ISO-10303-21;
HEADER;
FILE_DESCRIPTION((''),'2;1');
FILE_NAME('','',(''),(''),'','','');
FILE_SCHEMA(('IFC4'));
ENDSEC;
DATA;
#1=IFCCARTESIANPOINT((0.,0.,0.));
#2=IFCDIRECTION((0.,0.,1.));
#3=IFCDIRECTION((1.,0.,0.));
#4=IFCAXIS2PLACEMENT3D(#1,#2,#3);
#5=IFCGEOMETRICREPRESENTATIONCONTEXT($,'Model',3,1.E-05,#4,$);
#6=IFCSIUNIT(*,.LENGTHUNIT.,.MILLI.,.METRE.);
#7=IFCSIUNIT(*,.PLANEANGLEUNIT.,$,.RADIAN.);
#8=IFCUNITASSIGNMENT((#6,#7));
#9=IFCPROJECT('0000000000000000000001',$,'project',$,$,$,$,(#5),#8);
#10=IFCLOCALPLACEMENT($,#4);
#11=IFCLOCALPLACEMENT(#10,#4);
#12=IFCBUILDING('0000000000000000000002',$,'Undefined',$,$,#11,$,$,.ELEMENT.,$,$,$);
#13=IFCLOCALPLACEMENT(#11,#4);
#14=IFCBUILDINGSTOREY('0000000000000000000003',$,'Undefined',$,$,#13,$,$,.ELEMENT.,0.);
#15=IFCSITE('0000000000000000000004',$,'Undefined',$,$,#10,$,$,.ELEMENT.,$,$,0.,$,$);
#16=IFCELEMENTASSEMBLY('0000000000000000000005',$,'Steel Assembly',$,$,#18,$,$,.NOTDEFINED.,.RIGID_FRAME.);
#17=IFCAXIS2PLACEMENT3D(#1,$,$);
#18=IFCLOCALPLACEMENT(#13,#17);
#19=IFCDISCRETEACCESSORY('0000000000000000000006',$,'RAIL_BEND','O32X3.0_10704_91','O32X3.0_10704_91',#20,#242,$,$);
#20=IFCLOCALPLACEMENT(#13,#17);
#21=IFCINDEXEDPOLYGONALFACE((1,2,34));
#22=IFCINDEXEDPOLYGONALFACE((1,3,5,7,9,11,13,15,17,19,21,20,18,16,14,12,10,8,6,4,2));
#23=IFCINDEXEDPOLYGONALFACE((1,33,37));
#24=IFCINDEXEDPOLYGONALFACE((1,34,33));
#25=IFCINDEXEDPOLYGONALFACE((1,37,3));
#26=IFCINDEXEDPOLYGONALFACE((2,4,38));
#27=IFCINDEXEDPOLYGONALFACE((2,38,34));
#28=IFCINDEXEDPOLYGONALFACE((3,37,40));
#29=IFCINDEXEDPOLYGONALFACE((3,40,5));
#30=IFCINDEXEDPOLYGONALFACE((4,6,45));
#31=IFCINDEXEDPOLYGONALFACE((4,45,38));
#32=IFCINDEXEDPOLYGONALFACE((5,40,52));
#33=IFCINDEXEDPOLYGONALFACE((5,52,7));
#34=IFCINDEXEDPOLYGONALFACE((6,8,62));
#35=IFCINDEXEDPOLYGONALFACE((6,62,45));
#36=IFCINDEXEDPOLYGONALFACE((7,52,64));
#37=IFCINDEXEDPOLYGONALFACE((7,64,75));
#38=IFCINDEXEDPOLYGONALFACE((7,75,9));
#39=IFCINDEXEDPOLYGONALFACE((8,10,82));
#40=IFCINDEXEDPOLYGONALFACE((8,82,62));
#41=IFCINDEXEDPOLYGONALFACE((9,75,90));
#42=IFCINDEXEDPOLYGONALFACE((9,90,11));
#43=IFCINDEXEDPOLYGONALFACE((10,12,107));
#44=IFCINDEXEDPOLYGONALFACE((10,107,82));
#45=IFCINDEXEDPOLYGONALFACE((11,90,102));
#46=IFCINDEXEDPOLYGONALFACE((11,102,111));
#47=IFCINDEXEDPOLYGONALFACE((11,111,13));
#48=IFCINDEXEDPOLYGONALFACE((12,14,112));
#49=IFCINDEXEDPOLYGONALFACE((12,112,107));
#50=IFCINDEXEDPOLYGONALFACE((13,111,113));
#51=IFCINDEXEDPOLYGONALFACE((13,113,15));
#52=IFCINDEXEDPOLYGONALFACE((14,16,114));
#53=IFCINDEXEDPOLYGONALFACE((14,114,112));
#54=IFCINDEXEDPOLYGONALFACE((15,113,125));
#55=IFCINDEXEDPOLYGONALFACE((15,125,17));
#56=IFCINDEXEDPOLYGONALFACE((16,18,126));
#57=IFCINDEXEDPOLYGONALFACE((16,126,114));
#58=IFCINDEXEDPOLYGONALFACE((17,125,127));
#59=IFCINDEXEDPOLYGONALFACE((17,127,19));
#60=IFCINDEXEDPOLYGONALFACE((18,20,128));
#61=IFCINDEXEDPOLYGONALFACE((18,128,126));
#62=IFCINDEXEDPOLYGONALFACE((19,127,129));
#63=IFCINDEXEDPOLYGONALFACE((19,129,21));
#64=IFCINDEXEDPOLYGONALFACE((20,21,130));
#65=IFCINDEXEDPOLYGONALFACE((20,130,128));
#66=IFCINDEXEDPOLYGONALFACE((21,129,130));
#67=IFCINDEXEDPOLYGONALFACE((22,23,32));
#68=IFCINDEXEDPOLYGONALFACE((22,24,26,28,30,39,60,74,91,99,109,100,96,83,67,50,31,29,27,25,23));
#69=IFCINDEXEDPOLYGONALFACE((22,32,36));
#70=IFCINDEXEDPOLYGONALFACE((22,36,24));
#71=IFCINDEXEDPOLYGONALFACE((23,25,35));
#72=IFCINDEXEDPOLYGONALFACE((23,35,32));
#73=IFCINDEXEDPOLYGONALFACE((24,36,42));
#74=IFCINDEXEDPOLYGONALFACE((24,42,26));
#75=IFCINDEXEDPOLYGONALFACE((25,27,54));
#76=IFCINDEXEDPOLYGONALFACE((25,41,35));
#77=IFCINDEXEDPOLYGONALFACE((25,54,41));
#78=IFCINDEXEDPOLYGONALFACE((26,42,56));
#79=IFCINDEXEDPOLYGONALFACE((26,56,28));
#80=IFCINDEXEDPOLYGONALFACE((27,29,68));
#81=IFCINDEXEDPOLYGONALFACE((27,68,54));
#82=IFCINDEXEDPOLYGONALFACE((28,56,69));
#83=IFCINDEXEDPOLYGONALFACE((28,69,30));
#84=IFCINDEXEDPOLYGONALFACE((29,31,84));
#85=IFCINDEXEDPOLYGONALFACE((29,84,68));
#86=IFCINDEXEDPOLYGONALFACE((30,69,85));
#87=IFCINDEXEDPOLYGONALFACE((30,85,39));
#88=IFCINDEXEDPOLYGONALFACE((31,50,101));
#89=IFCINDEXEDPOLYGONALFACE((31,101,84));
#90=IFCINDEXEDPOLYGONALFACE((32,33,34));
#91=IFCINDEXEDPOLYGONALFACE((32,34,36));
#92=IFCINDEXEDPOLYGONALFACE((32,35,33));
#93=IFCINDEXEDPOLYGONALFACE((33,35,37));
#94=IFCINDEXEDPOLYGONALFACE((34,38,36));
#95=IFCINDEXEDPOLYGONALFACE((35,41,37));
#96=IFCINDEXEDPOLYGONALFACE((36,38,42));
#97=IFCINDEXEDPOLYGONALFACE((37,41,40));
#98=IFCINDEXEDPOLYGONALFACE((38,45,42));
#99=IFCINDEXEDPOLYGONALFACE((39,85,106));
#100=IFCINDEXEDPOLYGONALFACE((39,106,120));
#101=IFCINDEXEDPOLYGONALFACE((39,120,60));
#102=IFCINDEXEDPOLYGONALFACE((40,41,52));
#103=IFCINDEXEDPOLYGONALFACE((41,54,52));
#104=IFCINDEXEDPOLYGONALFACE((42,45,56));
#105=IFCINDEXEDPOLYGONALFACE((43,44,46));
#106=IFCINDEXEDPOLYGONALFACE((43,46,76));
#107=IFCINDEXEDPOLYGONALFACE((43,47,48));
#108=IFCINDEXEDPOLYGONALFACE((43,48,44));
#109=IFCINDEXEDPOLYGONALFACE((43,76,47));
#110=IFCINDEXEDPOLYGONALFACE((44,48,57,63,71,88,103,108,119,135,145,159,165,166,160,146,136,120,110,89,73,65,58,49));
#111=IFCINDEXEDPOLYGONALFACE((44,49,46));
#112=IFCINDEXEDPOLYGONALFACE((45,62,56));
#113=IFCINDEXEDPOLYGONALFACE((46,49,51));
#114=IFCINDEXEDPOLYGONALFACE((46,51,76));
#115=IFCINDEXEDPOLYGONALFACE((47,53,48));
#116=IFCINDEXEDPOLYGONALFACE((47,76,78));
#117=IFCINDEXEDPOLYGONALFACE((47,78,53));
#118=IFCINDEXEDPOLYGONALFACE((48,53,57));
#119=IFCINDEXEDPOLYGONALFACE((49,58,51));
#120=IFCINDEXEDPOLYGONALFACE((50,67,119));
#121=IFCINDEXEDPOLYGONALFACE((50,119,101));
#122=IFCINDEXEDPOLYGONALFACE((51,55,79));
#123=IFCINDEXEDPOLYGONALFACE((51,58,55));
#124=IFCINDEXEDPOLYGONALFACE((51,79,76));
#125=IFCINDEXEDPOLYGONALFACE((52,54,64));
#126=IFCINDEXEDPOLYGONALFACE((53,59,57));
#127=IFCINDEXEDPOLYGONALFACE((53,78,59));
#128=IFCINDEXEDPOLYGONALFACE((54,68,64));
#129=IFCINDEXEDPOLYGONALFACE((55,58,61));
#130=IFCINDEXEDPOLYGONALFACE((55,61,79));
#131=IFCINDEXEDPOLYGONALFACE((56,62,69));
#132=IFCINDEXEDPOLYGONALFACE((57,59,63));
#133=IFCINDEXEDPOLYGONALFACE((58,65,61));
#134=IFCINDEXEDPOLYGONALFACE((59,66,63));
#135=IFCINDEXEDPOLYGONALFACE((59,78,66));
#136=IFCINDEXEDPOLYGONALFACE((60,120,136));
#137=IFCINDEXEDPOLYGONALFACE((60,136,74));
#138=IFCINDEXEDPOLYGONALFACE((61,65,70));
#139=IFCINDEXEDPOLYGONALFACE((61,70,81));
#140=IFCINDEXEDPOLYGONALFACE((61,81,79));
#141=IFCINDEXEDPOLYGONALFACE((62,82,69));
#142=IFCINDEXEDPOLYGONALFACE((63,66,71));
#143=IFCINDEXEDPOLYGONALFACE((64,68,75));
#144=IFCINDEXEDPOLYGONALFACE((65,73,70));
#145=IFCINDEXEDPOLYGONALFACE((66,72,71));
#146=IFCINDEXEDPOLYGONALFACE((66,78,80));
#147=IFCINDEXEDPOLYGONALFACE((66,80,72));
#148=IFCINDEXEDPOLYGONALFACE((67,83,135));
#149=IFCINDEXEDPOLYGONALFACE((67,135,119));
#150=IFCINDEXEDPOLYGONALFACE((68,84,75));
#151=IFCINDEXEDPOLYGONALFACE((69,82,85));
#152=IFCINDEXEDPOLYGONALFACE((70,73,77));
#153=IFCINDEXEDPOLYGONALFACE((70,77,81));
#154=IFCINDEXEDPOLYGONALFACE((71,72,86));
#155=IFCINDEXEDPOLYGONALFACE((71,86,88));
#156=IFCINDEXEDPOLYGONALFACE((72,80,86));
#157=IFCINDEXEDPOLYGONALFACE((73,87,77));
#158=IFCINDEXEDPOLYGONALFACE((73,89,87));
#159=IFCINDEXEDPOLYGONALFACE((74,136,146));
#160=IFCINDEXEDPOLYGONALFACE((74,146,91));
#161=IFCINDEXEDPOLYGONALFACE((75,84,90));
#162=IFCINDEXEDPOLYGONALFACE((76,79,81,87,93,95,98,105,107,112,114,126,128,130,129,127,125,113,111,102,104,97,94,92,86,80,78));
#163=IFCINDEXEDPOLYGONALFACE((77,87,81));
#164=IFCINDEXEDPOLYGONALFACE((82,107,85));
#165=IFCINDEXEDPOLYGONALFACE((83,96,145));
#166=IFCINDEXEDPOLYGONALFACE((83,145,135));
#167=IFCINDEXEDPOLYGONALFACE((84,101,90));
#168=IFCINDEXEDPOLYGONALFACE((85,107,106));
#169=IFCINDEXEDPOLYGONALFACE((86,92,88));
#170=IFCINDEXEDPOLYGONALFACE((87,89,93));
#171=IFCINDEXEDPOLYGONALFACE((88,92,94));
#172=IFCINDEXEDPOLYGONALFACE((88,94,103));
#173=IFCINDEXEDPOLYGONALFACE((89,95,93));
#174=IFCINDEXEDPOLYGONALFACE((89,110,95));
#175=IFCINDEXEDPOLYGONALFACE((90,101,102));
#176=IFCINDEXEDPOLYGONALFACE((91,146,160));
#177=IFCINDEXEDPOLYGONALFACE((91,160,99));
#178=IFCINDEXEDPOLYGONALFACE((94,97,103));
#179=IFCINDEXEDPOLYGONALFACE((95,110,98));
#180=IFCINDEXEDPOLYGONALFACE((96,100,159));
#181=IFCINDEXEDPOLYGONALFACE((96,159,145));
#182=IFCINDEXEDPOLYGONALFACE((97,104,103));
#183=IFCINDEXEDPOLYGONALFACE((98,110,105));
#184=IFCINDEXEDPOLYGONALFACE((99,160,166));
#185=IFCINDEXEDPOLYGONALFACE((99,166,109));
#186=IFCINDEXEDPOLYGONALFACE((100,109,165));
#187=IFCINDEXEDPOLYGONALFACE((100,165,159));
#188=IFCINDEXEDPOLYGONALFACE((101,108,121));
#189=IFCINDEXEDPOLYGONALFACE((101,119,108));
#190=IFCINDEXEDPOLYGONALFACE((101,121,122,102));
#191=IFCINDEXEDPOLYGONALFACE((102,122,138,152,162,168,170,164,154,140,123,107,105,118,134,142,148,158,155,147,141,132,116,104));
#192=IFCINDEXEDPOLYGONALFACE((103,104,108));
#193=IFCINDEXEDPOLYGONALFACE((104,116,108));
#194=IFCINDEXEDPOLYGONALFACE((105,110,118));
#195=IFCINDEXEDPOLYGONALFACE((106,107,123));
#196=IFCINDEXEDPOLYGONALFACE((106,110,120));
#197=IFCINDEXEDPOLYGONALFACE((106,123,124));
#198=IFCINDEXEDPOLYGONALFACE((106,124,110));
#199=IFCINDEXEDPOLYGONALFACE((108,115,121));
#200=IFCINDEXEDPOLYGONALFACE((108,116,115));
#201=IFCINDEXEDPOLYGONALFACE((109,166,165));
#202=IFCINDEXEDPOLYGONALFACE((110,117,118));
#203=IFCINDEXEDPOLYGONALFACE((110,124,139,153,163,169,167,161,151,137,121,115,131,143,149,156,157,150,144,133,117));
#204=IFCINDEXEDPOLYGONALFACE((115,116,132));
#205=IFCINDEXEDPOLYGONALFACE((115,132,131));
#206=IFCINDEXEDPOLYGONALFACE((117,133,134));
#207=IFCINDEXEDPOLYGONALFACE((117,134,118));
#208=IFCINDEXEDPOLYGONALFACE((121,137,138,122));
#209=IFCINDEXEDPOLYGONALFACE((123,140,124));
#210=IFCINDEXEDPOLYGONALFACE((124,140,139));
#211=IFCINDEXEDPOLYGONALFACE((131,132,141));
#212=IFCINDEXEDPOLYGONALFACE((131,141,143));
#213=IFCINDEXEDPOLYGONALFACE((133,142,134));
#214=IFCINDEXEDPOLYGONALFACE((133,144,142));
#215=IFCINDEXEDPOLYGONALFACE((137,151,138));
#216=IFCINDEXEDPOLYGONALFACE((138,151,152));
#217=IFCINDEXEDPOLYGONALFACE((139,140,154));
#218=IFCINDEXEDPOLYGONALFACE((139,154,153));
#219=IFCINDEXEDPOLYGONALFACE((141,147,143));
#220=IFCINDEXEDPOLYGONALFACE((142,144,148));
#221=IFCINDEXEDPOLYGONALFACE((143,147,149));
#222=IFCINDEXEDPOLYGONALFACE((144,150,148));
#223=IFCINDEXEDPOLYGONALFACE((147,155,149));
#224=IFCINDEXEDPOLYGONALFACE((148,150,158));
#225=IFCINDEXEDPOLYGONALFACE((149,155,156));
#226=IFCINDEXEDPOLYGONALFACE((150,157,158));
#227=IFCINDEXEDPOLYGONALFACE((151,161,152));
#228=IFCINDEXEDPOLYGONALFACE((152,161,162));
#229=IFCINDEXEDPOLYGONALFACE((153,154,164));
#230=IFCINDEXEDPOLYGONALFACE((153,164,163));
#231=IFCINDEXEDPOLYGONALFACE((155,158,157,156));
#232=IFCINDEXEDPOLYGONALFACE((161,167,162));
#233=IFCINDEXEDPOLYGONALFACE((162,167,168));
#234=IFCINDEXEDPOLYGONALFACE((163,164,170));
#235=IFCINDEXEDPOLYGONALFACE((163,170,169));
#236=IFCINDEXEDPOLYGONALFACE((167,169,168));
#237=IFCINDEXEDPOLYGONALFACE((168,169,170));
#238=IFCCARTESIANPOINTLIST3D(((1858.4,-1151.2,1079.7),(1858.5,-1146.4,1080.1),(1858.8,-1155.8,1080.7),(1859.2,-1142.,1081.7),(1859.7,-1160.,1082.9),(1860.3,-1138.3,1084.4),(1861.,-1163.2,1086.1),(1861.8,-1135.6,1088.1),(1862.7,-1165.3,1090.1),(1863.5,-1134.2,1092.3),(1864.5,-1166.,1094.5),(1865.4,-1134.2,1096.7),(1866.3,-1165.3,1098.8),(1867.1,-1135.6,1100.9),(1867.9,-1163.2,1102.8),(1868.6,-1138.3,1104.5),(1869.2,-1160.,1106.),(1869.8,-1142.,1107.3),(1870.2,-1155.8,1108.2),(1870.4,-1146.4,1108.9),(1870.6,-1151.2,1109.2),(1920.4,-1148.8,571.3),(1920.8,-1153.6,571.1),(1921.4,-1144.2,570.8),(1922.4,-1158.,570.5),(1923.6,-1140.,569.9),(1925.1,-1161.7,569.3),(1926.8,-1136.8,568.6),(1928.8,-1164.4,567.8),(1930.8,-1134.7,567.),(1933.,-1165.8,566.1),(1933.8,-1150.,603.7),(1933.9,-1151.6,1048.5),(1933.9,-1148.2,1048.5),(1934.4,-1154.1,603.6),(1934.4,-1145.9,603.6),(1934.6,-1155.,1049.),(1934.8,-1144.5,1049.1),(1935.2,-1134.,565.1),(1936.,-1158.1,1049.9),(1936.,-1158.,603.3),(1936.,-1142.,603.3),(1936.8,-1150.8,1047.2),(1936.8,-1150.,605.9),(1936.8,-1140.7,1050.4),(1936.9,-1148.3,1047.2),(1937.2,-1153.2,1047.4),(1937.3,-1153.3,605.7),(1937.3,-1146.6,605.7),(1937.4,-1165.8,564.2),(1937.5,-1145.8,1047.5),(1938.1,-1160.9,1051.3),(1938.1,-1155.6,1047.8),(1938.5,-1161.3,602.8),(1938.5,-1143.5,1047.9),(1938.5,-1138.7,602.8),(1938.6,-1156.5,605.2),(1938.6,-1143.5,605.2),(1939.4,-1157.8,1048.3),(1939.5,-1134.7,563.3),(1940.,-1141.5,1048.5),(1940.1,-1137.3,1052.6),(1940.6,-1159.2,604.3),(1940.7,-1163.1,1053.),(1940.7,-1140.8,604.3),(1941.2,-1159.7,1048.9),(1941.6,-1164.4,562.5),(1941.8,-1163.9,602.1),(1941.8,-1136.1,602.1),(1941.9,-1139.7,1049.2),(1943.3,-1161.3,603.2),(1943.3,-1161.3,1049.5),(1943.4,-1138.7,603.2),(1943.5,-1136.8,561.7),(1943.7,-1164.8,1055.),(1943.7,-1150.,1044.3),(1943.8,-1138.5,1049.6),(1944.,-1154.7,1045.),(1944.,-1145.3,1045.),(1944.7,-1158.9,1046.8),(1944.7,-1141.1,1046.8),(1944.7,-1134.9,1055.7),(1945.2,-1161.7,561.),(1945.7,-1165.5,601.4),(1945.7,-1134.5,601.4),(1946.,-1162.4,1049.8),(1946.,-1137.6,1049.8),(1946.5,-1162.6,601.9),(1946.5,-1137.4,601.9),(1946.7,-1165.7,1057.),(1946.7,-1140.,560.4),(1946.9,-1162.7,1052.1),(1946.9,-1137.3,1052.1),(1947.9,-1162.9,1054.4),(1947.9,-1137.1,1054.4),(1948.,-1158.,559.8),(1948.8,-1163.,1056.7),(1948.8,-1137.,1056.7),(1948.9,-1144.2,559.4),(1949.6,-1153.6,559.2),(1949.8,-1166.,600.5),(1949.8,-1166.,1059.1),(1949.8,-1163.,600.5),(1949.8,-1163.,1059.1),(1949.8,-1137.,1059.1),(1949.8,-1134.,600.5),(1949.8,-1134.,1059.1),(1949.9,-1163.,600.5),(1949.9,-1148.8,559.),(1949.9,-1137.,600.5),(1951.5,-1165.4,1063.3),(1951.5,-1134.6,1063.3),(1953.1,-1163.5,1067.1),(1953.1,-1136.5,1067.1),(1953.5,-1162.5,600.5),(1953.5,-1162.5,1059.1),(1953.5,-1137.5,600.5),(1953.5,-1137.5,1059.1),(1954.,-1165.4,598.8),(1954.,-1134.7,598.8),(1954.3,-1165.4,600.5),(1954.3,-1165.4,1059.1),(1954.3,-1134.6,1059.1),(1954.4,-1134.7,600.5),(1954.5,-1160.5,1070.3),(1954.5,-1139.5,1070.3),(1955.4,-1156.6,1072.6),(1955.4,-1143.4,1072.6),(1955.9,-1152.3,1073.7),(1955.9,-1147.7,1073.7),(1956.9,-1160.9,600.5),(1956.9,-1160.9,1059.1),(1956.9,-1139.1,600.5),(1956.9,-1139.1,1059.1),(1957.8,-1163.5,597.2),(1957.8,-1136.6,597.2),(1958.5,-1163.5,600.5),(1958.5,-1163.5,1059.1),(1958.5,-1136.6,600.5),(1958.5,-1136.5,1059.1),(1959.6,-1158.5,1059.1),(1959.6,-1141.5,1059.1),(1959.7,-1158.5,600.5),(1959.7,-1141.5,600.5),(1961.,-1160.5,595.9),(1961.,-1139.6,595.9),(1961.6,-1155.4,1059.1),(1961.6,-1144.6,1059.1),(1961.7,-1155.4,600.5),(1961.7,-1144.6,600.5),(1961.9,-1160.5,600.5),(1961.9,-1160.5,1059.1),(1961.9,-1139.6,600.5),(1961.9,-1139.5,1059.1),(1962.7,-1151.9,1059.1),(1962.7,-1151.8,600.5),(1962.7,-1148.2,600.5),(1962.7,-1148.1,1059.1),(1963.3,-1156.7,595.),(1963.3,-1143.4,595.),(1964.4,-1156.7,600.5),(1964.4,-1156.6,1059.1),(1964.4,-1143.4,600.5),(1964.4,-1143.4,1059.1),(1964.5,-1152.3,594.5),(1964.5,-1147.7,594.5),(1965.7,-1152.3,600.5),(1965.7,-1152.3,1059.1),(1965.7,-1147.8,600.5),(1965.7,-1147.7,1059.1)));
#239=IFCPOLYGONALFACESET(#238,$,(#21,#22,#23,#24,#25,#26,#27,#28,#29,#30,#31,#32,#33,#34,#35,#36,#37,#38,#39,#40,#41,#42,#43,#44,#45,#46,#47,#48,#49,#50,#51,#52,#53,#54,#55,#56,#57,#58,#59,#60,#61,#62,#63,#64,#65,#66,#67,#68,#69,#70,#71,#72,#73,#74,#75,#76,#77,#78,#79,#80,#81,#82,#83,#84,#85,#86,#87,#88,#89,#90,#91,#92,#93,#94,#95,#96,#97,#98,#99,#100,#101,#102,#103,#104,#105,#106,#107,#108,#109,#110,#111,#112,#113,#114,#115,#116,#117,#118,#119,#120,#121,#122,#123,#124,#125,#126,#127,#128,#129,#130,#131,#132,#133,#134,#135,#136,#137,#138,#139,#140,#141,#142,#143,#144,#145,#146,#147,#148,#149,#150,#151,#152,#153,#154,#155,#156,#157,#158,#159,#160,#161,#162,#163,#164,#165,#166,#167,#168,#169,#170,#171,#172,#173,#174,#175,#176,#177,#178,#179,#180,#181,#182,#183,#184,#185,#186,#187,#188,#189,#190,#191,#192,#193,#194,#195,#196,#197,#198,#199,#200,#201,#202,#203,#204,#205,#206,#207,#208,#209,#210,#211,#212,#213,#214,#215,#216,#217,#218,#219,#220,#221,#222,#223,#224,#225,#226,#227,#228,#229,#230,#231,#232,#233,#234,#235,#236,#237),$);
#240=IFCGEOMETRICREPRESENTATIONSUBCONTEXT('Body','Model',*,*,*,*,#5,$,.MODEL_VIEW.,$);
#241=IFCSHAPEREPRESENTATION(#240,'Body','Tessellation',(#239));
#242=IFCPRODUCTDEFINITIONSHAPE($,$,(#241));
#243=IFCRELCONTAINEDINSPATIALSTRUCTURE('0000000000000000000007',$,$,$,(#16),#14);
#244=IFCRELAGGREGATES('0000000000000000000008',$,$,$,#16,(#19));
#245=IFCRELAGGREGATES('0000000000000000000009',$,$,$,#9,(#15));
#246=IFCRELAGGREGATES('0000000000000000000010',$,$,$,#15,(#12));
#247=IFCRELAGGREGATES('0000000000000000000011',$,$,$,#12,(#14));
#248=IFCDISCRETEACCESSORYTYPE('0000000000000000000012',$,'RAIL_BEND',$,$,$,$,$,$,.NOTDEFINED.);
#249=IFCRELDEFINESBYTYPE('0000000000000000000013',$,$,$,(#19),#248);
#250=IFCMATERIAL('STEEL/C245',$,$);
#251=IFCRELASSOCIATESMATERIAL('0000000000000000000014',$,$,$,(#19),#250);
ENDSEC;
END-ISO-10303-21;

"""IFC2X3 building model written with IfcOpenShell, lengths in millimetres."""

from ifc_helpers import new_model, si_unit, frame, origin_with_axes, origin_2d_with_axis, place, context, subcontext, project, spatial, circle, hollow_circle, extrude, boolean, material, type_object, element, aggregate, save


model = new_model("IFC2X3")

# Units and contexts
model_context = context("Model", 3, precision=1e-05, world=origin_with_axes())
body_context = subcontext(model_context, "Body", "Model", "MODEL_VIEW")
ifc_project = project(units=[si_unit("LENGTHUNIT", "METRE", prefix="MILLI"), si_unit("PLANEANGLEUNIT", "RADIAN")], contexts=[model_context])

# Site, building, storey
site_placement = place(None, origin_with_axes())
site = spatial("IfcSite", under=ifc_project, at=site_placement, Name="Undefined", CompositionType="ELEMENT", RefElevation=0.0)
building_placement = place(site_placement, origin_with_axes())
building = spatial("IfcBuilding", under=site, at=building_placement, Name="Undefined", CompositionType="ELEMENT")
storey_placement = place(building_placement, origin_with_axes())
storey = spatial("IfcBuildingStorey", under=building, at=storey_placement, Name="Undefined", CompositionType="ELEMENT", Elevation=0.0)

# Shared definitions
ifc_material_1 = material(Name="STEEL/C245")

# Element assembly, discrete accessory
discrete_accessory_type_1 = type_object("IfcDiscreteAccessoryType", Name="RAIL_BEND")
assembly_1_placement = place(storey_placement, origin_with_axes())
assembly_1 = element("IfcElementAssembly", 1, at=assembly_1_placement, inside=storey, Name="Steel Assembly", AssemblyPlace="NOTDEFINED", PredefinedType="RIGID_FRAME")
discrete_accessory_1_placement = place(assembly_1_placement, frame((1949.8, -1150.0, 600.5), z_axis=(0.0, 0.0, 1.0), x_axis=(-1.0, 0.0, 0.0)))
discrete_accessory_1 = element("IfcDiscreteAccessory", 2, at=discrete_accessory_1_placement, type_object=discrete_accessory_type_1, material=ifc_material_1, Name="RAIL_BEND", Description="O32X3.0_10704_91", ObjectType="O32X3.0_10704_91", context=body_context, shape_type="CSG", body=[
    boolean("UNION", boolean("UNION", extrude(hollow_circle(Radius=16.0, WallThickness=3.0, at=origin_2d_with_axis()), frame((0.0, 0.0, 458.6), z_axis=(0.0, 0.0, -1.0), x_axis=(0.0, 1.0, 0.0)), (0.0, 0.0, 1.0), 458.6), extrude(circle(Radius=16.0, at=origin_2d_with_axis()), frame((0.0, 0.0, 458.6), z_axis=(0.92388, 0.0, 0.382683), x_axis=(0.0, 1.0, 0.0)), (0.0, 0.0, 1.0), 92.4)), extrude(circle(Radius=16.0, at=origin_2d_with_axis()), frame((0.0, 0.0, 0.0), z_axis=(0.382683, 0.0, -0.92388), x_axis=(0.0, -1.0, 0.0)), (0.0, 0.0, 1.0), 38.3)),
])
aggregate(assembly_1, [discrete_accessory_1])

save(model, "model.ifc")
